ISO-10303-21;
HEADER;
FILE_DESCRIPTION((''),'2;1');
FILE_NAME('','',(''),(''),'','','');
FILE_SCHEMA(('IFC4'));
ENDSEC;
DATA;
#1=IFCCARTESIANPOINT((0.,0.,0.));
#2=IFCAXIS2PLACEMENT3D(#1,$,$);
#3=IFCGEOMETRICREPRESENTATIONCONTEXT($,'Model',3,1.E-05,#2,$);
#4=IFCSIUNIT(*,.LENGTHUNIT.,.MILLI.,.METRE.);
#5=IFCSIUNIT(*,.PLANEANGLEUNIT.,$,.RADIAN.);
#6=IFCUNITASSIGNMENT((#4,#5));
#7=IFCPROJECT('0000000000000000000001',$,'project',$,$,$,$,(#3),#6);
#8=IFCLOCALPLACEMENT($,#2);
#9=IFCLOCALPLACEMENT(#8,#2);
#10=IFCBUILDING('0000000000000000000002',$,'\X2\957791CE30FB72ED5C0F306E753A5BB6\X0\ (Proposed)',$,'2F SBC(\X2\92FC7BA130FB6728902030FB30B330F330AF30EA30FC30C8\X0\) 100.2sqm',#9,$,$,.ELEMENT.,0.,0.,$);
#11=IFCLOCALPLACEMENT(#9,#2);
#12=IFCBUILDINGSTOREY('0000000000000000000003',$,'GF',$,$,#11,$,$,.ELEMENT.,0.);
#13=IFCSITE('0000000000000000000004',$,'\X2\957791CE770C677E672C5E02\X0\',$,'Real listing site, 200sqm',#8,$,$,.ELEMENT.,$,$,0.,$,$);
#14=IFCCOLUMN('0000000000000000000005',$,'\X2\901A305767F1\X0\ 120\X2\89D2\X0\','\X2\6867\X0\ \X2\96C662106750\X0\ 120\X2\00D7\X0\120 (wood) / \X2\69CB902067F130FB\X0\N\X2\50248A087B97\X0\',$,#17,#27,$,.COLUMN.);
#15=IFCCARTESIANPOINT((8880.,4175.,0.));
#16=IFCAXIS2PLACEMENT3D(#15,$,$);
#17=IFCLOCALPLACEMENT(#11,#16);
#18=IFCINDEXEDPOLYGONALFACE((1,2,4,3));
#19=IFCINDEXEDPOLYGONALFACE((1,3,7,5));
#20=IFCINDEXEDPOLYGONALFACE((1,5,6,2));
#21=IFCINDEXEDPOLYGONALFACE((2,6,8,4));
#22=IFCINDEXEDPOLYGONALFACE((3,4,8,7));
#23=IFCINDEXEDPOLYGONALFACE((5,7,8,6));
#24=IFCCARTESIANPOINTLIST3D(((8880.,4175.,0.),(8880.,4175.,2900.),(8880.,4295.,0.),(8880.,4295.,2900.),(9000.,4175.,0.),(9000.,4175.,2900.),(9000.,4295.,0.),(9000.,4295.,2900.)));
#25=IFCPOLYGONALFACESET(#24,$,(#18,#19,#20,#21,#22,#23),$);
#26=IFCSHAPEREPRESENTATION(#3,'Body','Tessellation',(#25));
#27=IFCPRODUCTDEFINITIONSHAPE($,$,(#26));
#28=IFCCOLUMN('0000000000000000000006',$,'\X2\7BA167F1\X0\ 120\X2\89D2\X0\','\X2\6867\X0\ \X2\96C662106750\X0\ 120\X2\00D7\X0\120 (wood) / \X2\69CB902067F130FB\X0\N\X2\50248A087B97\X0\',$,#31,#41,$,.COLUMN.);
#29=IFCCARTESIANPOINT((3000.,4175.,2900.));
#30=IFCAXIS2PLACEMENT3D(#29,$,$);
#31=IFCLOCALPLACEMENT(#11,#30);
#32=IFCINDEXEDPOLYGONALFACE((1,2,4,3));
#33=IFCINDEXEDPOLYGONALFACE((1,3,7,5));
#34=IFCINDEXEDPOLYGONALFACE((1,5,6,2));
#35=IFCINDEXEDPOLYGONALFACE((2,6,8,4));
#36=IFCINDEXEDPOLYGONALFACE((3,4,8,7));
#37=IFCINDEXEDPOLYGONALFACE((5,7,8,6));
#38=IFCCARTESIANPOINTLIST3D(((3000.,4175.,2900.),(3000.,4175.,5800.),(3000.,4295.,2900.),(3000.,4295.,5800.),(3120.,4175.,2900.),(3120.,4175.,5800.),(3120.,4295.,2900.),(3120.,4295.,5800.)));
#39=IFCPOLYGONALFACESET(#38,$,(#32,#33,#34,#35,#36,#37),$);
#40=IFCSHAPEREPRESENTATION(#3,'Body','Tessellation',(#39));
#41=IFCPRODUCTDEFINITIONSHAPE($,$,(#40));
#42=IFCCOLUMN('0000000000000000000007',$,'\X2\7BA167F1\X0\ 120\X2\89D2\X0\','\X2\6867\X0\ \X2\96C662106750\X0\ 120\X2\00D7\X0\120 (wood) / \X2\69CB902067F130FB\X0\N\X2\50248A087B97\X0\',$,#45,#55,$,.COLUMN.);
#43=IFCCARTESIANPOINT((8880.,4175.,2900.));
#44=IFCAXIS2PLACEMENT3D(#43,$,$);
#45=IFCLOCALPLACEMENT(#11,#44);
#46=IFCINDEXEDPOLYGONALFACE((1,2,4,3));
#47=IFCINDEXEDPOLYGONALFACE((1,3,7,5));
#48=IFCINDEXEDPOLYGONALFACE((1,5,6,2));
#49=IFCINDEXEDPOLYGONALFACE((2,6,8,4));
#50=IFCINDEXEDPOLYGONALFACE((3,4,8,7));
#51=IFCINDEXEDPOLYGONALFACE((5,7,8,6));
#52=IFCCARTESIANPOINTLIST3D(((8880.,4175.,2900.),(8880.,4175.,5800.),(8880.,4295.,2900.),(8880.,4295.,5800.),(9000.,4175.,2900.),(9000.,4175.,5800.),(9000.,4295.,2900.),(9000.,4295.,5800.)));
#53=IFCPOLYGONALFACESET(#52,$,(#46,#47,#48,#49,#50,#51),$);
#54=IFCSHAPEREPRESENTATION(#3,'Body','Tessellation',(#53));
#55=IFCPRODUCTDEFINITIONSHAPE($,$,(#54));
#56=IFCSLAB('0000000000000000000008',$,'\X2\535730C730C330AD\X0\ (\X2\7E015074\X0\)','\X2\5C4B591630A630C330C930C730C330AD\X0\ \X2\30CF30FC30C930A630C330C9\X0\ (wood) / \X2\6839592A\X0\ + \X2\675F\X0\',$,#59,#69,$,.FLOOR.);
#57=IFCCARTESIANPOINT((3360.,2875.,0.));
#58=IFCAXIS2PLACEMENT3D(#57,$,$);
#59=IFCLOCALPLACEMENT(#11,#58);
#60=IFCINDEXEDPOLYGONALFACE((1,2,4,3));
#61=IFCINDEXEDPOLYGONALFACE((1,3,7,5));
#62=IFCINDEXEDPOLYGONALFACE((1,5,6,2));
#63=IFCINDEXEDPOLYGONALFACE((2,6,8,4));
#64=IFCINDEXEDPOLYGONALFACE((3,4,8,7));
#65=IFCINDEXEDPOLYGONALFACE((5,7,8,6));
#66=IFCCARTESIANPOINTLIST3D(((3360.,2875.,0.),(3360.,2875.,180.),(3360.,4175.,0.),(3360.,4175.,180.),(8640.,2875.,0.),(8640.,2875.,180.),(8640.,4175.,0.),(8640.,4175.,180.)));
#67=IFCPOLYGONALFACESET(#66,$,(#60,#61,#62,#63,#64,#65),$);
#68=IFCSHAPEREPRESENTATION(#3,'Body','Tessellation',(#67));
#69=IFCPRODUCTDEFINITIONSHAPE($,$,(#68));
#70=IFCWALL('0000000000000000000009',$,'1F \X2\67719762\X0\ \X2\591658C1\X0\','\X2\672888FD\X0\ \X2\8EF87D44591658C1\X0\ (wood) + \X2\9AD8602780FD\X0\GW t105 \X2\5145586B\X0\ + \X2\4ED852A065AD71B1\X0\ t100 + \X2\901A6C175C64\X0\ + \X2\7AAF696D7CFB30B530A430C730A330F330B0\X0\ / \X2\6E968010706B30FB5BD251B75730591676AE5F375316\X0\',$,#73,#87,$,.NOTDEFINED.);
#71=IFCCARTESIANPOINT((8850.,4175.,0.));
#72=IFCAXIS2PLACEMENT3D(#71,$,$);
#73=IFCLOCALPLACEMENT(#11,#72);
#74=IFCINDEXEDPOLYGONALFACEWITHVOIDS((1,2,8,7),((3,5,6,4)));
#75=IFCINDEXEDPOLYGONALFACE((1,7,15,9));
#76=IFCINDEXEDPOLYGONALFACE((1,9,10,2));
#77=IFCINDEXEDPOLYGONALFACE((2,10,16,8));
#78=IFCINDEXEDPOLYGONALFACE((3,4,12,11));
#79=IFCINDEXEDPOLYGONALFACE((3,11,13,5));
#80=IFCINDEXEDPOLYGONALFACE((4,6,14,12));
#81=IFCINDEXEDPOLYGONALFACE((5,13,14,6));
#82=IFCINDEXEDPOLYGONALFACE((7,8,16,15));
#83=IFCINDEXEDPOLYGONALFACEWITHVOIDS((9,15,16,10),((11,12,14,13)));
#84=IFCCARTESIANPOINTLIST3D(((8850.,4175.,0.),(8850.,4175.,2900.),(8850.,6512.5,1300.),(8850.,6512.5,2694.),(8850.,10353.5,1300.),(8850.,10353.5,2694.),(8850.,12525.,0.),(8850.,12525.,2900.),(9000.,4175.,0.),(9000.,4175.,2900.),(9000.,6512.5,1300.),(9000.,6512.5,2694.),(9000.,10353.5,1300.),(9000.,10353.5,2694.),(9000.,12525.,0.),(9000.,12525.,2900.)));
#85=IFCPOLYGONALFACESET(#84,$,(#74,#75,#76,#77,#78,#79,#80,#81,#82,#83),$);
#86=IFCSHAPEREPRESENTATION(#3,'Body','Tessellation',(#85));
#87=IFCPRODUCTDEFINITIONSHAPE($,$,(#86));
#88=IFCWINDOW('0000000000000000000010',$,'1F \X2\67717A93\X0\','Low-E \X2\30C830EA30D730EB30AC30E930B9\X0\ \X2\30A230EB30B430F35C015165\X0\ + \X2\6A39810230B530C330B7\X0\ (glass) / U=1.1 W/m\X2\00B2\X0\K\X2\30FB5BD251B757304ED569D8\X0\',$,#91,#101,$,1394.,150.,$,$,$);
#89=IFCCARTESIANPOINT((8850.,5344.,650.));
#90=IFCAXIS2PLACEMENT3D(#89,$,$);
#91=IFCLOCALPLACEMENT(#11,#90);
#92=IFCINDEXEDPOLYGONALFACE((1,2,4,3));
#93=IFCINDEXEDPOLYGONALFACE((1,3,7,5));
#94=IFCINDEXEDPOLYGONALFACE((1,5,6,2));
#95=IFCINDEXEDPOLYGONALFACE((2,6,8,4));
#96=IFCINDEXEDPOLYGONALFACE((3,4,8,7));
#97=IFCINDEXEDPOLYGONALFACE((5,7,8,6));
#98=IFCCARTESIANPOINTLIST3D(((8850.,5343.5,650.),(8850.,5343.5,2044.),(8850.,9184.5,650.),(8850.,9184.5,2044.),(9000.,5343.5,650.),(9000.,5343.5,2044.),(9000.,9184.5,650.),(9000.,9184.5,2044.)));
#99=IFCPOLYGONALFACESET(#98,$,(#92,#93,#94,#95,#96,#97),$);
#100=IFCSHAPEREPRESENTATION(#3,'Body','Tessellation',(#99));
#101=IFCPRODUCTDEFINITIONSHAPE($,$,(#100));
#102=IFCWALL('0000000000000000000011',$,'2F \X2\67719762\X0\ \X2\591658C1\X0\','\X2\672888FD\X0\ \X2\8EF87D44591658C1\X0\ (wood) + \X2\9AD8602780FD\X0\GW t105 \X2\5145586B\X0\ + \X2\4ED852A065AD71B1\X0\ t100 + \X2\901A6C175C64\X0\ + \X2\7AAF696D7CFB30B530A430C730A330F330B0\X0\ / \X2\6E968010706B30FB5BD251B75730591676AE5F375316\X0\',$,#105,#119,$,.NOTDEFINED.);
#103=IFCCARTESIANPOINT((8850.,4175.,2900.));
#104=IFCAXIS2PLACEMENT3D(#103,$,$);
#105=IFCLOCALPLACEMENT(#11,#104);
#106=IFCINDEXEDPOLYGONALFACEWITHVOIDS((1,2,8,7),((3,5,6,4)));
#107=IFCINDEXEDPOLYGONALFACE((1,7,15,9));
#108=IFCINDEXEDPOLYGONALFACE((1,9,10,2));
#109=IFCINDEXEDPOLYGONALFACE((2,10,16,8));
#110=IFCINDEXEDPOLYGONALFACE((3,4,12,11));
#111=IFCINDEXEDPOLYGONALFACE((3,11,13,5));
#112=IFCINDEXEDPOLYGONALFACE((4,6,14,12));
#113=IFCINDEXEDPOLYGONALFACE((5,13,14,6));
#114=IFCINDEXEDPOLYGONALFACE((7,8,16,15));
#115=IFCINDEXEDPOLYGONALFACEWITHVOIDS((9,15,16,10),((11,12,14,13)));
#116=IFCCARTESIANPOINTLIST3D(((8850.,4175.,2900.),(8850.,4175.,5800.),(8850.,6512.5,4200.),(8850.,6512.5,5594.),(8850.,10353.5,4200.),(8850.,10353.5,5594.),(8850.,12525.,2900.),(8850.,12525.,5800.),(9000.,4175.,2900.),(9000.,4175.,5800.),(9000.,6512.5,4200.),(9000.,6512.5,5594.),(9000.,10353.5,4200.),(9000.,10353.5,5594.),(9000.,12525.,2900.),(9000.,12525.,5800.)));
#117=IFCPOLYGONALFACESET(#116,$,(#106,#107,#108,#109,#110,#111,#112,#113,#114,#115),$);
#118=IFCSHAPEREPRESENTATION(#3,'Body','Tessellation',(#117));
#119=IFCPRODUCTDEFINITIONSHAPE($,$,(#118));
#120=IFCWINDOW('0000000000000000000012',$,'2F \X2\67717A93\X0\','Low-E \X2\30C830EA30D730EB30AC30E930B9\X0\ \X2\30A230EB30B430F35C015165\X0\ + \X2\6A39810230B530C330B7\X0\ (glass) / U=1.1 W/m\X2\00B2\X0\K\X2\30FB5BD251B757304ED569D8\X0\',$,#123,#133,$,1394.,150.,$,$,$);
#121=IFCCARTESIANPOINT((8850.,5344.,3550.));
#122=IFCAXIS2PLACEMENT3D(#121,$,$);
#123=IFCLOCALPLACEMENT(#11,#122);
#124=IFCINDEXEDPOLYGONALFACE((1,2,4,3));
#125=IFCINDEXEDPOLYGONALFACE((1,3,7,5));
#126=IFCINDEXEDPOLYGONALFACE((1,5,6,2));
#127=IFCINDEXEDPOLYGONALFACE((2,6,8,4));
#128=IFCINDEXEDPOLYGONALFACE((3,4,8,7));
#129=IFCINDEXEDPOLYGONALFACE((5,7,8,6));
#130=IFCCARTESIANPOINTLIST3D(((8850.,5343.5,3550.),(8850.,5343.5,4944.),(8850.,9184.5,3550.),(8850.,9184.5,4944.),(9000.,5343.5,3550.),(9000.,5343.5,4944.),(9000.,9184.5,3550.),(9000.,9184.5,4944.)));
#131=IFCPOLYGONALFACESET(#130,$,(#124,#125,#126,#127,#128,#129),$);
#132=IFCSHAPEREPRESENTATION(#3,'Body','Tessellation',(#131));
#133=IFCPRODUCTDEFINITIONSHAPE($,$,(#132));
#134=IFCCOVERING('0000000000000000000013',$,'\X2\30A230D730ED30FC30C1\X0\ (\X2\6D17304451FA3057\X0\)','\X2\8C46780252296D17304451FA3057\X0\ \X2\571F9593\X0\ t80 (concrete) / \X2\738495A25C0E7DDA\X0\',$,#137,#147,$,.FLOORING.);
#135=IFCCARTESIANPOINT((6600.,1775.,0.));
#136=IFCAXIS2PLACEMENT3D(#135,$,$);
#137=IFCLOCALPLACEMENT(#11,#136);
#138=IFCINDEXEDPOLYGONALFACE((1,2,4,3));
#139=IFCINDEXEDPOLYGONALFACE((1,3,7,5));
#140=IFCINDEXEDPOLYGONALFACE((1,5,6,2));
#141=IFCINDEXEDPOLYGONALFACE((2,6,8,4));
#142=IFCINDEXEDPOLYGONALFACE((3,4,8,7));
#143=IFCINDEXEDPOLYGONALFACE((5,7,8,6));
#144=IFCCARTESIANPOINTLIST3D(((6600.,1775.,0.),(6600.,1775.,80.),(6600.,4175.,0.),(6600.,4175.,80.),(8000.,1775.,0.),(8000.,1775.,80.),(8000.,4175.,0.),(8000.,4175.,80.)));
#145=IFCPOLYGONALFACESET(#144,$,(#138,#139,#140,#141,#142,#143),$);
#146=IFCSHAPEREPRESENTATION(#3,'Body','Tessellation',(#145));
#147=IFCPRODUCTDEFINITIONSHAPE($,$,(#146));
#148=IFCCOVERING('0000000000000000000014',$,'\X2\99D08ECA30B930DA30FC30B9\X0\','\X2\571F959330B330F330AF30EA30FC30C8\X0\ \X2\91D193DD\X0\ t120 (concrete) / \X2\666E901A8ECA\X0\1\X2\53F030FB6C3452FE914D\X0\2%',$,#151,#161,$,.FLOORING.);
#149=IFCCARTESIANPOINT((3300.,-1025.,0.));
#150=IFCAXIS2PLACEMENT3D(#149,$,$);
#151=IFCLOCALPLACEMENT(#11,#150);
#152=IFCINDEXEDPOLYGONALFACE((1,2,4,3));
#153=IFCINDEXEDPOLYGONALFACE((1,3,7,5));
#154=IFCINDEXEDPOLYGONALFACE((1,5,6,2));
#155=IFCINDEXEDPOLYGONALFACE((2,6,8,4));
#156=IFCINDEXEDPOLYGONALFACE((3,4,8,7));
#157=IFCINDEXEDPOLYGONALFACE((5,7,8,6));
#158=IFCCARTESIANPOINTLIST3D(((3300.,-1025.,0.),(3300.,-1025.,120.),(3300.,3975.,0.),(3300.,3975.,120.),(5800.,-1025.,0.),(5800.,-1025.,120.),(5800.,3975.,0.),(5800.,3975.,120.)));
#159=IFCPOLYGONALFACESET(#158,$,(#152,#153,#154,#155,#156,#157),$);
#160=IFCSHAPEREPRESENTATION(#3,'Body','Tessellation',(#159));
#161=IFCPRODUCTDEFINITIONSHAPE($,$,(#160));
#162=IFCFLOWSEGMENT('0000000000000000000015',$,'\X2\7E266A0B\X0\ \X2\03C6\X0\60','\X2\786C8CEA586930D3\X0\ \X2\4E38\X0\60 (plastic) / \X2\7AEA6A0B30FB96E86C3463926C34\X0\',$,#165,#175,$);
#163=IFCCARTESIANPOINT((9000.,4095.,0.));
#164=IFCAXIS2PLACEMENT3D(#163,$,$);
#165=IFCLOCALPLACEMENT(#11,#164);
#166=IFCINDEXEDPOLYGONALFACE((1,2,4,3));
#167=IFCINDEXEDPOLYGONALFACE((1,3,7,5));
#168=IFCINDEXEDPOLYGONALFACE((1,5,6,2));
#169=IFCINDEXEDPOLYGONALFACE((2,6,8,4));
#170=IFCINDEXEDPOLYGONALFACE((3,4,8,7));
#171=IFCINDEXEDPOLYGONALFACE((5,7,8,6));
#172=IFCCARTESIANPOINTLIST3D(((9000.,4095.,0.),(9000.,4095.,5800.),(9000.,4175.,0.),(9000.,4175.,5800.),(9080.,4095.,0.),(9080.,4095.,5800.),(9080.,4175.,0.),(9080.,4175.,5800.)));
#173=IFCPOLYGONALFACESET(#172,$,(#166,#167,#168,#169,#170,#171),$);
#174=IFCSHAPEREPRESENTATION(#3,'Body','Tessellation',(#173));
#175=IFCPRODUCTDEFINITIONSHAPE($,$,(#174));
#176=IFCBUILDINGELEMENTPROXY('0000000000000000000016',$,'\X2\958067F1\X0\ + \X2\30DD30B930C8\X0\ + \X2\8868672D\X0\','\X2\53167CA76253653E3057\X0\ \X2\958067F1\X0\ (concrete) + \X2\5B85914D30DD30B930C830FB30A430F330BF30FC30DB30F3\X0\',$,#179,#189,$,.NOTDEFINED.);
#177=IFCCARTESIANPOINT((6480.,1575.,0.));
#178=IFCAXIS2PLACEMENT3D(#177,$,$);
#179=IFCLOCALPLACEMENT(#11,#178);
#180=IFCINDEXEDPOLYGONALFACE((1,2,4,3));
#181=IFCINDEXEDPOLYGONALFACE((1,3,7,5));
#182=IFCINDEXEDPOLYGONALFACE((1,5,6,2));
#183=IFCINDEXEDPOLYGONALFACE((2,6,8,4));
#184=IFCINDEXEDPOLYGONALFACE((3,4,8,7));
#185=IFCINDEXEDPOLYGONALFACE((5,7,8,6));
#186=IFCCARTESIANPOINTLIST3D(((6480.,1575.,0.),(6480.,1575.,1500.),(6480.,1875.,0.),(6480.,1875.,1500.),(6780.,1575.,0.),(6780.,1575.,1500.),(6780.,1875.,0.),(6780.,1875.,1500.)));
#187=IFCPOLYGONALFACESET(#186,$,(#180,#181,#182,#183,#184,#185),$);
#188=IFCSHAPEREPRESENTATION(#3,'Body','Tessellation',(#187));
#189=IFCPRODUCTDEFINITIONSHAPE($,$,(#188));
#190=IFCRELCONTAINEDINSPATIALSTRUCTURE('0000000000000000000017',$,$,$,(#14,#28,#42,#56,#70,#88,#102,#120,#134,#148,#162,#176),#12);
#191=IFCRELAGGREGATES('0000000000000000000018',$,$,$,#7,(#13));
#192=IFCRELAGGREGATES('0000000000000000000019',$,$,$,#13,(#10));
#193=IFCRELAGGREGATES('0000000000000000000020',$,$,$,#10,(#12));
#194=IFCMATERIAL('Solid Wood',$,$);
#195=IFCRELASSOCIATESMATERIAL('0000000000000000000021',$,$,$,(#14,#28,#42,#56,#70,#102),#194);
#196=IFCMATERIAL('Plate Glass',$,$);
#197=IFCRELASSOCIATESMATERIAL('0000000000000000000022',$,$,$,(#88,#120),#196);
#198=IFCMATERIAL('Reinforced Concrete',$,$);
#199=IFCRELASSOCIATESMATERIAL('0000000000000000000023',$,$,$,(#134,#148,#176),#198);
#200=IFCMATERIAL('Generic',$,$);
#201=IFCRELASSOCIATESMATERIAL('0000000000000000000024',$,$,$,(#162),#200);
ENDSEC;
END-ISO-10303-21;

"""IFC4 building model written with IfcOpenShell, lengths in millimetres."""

from ifc_helpers import new_model, si_unit, frame, frame_2d, origin, place, context, project, spatial, rectangle, extrude, material, element, fill, save


model = new_model("IFC4")

# Units and contexts
model_context = context("Model", 3, precision=1e-05, world=origin())
ifc_project = project(units=[si_unit("LENGTHUNIT", "METRE", prefix="MILLI"), si_unit("PLANEANGLEUNIT", "RADIAN")], contexts=[model_context])

# Site, building, storey
site_placement = place(None, origin())
site = spatial("IfcSite", under=ifc_project, at=site_placement, Name="長野県松本市", ObjectType="Real listing site, 200sqm", CompositionType="ELEMENT", RefElevation=0.0)
building_placement = place(site_placement, origin())
building = spatial("IfcBuilding", under=site, at=building_placement, Name="長野・狭小の町家 (Proposed)", ObjectType="2F SBC(鋼管・木造・コンクリート) 100.2sqm", CompositionType="ELEMENT", ElevationOfRefHeight=0.0, ElevationOfTerrain=0.0)
storey_placement = place(building_placement, origin())
storey = spatial("IfcBuildingStorey", under=building, at=storey_placement, Name="GF", CompositionType="ELEMENT", Elevation=0.0)

# Columns
ifc_material_1 = material(Name="Solid Wood")
column_1_placement = place(storey_placement, frame((8880.0, 4175.0, 0.0)))
element("IfcColumn", 1, at=column_1_placement, inside=storey, material=ifc_material_1, Name="通し柱 120角", Description="桧 集成材 120×120 (wood) / 構造柱・N値計算", PredefinedType="COLUMN", context=model_context, shape_type="SweptSolid", body=[
    extrude(rectangle(XDim=120.0, YDim=120.0, at=frame_2d((60.0, 60.0))), frame((8880.0, 4175.0, 0.0)), (0.0, 0.0, 1.0), 2900.0),
])
column_2_placement = place(storey_placement, frame((3000.0, 4175.0, 2900.0)))
element("IfcColumn", 2, at=column_2_placement, inside=storey, material=ifc_material_1, Name="管柱 120角", Description="桧 集成材 120×120 (wood) / 構造柱・N値計算", PredefinedType="COLUMN", context=model_context, shape_type="SweptSolid", body=[
    extrude(rectangle(XDim=120.0, YDim=120.0, at=frame_2d((60.0, 60.0))), frame((3000.0, 4175.0, 2900.0)), (0.0, 0.0, 1.0), 2900.0),
])
column_3_placement = place(storey_placement, frame((8880.0, 4175.0, 2900.0)))
element("IfcColumn", 3, at=column_3_placement, inside=storey, material=ifc_material_1, Name="管柱 120角", Description="桧 集成材 120×120 (wood) / 構造柱・N値計算", PredefinedType="COLUMN", context=model_context, shape_type="SweptSolid", body=[
    extrude(rectangle(XDim=120.0, YDim=120.0, at=frame_2d((60.0, 60.0))), frame((8880.0, 4175.0, 2900.0)), (0.0, 0.0, 1.0), 2900.0),
])

# Slab
slab_placement = place(storey_placement, frame((3360.0, 2875.0, 0.0)))
element("IfcSlab", 4, at=slab_placement, inside=storey, material=ifc_material_1, Name="南デッキ (縁側)", Description="屋外ウッドデッキ ハードウッド (wood) / 根太 + 束", PredefinedType="FLOOR", context=model_context, shape_type="SweptSolid", body=[
    extrude(rectangle(XDim=5280.0, YDim=1300.0, at=frame_2d((2640.0, 650.0))), frame((3360.0, 2875.0, 0.0)), (0.0, 0.0, 1.0), 180.0),
])

# Walls, openings, windows
wall_1_placement = place(storey_placement, frame((8850.0, 4175.0, 0.0)))
wall_1 = element("IfcWall", 5, at=wall_1_placement, inside=storey, material=ifc_material_1, Name="1F 東面 外壁", Description="木製 軸組外壁 (wood) + 高性能GW t105 充填 + 付加断熱 t100 + 通気層 + 窯業系サイディング / 準耐火・寒冷地外皮強化", PredefinedType="NOTDEFINED", context=model_context, shape_type="SweptSolid", body=[
    extrude(rectangle(XDim=150.0, YDim=8350.0, at=frame_2d((75.0, 4175.0))), frame((8850.0, 4175.0, 0.0)), (0.0, 0.0, 1.0), 2900.0),
])
opening_1_placement = place(storey_placement, frame((8850.0, 5344.0, 650.0)))
opening_1 = element("IfcOpeningElement", 6, at=opening_1_placement, cuts=wall_1, PredefinedType="NOTDEFINED", context=model_context, shape_type="SweptSolid", body=[
    extrude(rectangle(XDim=150.0, YDim=3841.0, at=frame_2d((75.0, 1920.0))), frame((8850.0, 5344.0, 650.0)), (0.0, 0.0, 1.0), 1394.0),
])
ifc_material_2 = material(Name="Plate Glass")
window_1_placement = place(storey_placement, frame((8850.0, 5344.0, 650.0)))
window_1 = element("IfcWindow", 7, at=window_1_placement, inside=storey, material=ifc_material_2, Name="1F 東窓", Description="Low-E トリプルガラス アルゴン封入 + 樹脂サッシ (glass) / U=1.1 W/m²K・寒冷地仕様", OverallHeight=1394.0, OverallWidth=150.0, context=model_context, shape_type="SweptSolid", body=[
    extrude(rectangle(XDim=150.0, YDim=3841.0, at=frame_2d((75.0, 1920.0))), frame((8850.0, 5344.0, 650.0)), (0.0, 0.0, 1.0), 1394.0),
])
fill(opening_1, window_1)
wall_2_placement = place(storey_placement, frame((8850.0, 4175.0, 2900.0)))
wall_2 = element("IfcWall", 8, at=wall_2_placement, inside=storey, material=ifc_material_1, Name="2F 東面 外壁", Description="木製 軸組外壁 (wood) + 高性能GW t105 充填 + 付加断熱 t100 + 通気層 + 窯業系サイディング / 準耐火・寒冷地外皮強化", PredefinedType="NOTDEFINED", context=model_context, shape_type="SweptSolid", body=[
    extrude(rectangle(XDim=150.0, YDim=8350.0, at=frame_2d((75.0, 4175.0))), frame((8850.0, 4175.0, 2900.0)), (0.0, 0.0, 1.0), 2900.0),
])
opening_2_placement = place(storey_placement, frame((8850.0, 5344.0, 3550.0)))
opening_2 = element("IfcOpeningElement", 9, at=opening_2_placement, cuts=wall_2, PredefinedType="NOTDEFINED", context=model_context, shape_type="SweptSolid", body=[
    extrude(rectangle(XDim=150.0, YDim=3841.0, at=frame_2d((75.0, 1920.0))), frame((8850.0, 5344.0, 3550.0)), (0.0, 0.0, 1.0), 1394.0),
])
window_2_placement = place(storey_placement, frame((8850.0, 5344.0, 3550.0)))
window_2 = element("IfcWindow", 10, at=window_2_placement, inside=storey, material=ifc_material_2, Name="2F 東窓", Description="Low-E トリプルガラス アルゴン封入 + 樹脂サッシ (glass) / U=1.1 W/m²K・寒冷地仕様", OverallHeight=1394.0, OverallWidth=150.0, context=model_context, shape_type="SweptSolid", body=[
    extrude(rectangle(XDim=150.0, YDim=3841.0, at=frame_2d((75.0, 1920.0))), frame((8850.0, 5344.0, 3550.0)), (0.0, 0.0, 1.0), 1394.0),
])
fill(opening_2, window_2)

# Coverings
ifc_material_3 = material(Name="Reinforced Concrete")
covering_1_placement = place(storey_placement, frame((6600.0, 1775.0, 0.0)))
element("IfcCovering", 11, at=covering_1_placement, inside=storey, material=ifc_material_3, Name="アプローチ (洗い出し)", Description="豆砂利洗い出し 土間 t80 (concrete) / 玄関導線", PredefinedType="FLOORING", context=model_context, shape_type="SweptSolid", body=[
    extrude(rectangle(XDim=1400.0, YDim=2400.0, at=frame_2d((700.0, 1200.0))), frame((6600.0, 1775.0, 0.0)), (0.0, 0.0, 1.0), 80.0),
])
covering_2_placement = place(storey_placement, frame((3300.0, -1025.0, 0.0)))
element("IfcCovering", 12, at=covering_2_placement, inside=storey, material=ifc_material_3, Name="駐車スペース", Description="土間コンクリート 金鏝 t120 (concrete) / 普通車1台・水勾配2%", PredefinedType="FLOORING", context=model_context, shape_type="SweptSolid", body=[
    extrude(rectangle(XDim=2500.0, YDim=5000.0, at=frame_2d((1250.0, 2500.0))), frame((3300.0, -1025.0, 0.0)), (0.0, 0.0, 1.0), 120.0),
])

# Flow segment
ifc_material_4 = material(Name="Generic")
flow_segment_placement = place(storey_placement, frame((9000.0, 4095.0, 0.0)))
element("IfcFlowSegment", 13, at=flow_segment_placement, inside=storey, material=ifc_material_4, Name="縦樋 φ60", Description="硬質塩ビ 丸60 (plastic) / 竪樋・雨水排水", context=model_context, shape_type="SweptSolid", body=[
    extrude(rectangle(XDim=80.0, YDim=80.0, at=frame_2d((40.0, 40.0))), frame((9000.0, 4095.0, 0.0)), (0.0, 0.0, 1.0), 5800.0),
])

# Building element proxy
proxy_placement = place(storey_placement, frame((6480.0, 1575.0, 0.0)))
element("IfcBuildingElementProxy", 14, at=proxy_placement, inside=storey, material=ifc_material_3, Name="門柱 + ポスト + 表札", Description="化粧打放し 門柱 (concrete) + 宅配ポスト・インターホン", PredefinedType="NOTDEFINED", context=model_context, shape_type="SweptSolid", body=[
    extrude(rectangle(XDim=300.0, YDim=300.0, at=frame_2d((150.0, 150.0))), frame((6480.0, 1575.0, 0.0)), (0.0, 0.0, 1.0), 1500.0),
])

save(model, "model.ifc")
